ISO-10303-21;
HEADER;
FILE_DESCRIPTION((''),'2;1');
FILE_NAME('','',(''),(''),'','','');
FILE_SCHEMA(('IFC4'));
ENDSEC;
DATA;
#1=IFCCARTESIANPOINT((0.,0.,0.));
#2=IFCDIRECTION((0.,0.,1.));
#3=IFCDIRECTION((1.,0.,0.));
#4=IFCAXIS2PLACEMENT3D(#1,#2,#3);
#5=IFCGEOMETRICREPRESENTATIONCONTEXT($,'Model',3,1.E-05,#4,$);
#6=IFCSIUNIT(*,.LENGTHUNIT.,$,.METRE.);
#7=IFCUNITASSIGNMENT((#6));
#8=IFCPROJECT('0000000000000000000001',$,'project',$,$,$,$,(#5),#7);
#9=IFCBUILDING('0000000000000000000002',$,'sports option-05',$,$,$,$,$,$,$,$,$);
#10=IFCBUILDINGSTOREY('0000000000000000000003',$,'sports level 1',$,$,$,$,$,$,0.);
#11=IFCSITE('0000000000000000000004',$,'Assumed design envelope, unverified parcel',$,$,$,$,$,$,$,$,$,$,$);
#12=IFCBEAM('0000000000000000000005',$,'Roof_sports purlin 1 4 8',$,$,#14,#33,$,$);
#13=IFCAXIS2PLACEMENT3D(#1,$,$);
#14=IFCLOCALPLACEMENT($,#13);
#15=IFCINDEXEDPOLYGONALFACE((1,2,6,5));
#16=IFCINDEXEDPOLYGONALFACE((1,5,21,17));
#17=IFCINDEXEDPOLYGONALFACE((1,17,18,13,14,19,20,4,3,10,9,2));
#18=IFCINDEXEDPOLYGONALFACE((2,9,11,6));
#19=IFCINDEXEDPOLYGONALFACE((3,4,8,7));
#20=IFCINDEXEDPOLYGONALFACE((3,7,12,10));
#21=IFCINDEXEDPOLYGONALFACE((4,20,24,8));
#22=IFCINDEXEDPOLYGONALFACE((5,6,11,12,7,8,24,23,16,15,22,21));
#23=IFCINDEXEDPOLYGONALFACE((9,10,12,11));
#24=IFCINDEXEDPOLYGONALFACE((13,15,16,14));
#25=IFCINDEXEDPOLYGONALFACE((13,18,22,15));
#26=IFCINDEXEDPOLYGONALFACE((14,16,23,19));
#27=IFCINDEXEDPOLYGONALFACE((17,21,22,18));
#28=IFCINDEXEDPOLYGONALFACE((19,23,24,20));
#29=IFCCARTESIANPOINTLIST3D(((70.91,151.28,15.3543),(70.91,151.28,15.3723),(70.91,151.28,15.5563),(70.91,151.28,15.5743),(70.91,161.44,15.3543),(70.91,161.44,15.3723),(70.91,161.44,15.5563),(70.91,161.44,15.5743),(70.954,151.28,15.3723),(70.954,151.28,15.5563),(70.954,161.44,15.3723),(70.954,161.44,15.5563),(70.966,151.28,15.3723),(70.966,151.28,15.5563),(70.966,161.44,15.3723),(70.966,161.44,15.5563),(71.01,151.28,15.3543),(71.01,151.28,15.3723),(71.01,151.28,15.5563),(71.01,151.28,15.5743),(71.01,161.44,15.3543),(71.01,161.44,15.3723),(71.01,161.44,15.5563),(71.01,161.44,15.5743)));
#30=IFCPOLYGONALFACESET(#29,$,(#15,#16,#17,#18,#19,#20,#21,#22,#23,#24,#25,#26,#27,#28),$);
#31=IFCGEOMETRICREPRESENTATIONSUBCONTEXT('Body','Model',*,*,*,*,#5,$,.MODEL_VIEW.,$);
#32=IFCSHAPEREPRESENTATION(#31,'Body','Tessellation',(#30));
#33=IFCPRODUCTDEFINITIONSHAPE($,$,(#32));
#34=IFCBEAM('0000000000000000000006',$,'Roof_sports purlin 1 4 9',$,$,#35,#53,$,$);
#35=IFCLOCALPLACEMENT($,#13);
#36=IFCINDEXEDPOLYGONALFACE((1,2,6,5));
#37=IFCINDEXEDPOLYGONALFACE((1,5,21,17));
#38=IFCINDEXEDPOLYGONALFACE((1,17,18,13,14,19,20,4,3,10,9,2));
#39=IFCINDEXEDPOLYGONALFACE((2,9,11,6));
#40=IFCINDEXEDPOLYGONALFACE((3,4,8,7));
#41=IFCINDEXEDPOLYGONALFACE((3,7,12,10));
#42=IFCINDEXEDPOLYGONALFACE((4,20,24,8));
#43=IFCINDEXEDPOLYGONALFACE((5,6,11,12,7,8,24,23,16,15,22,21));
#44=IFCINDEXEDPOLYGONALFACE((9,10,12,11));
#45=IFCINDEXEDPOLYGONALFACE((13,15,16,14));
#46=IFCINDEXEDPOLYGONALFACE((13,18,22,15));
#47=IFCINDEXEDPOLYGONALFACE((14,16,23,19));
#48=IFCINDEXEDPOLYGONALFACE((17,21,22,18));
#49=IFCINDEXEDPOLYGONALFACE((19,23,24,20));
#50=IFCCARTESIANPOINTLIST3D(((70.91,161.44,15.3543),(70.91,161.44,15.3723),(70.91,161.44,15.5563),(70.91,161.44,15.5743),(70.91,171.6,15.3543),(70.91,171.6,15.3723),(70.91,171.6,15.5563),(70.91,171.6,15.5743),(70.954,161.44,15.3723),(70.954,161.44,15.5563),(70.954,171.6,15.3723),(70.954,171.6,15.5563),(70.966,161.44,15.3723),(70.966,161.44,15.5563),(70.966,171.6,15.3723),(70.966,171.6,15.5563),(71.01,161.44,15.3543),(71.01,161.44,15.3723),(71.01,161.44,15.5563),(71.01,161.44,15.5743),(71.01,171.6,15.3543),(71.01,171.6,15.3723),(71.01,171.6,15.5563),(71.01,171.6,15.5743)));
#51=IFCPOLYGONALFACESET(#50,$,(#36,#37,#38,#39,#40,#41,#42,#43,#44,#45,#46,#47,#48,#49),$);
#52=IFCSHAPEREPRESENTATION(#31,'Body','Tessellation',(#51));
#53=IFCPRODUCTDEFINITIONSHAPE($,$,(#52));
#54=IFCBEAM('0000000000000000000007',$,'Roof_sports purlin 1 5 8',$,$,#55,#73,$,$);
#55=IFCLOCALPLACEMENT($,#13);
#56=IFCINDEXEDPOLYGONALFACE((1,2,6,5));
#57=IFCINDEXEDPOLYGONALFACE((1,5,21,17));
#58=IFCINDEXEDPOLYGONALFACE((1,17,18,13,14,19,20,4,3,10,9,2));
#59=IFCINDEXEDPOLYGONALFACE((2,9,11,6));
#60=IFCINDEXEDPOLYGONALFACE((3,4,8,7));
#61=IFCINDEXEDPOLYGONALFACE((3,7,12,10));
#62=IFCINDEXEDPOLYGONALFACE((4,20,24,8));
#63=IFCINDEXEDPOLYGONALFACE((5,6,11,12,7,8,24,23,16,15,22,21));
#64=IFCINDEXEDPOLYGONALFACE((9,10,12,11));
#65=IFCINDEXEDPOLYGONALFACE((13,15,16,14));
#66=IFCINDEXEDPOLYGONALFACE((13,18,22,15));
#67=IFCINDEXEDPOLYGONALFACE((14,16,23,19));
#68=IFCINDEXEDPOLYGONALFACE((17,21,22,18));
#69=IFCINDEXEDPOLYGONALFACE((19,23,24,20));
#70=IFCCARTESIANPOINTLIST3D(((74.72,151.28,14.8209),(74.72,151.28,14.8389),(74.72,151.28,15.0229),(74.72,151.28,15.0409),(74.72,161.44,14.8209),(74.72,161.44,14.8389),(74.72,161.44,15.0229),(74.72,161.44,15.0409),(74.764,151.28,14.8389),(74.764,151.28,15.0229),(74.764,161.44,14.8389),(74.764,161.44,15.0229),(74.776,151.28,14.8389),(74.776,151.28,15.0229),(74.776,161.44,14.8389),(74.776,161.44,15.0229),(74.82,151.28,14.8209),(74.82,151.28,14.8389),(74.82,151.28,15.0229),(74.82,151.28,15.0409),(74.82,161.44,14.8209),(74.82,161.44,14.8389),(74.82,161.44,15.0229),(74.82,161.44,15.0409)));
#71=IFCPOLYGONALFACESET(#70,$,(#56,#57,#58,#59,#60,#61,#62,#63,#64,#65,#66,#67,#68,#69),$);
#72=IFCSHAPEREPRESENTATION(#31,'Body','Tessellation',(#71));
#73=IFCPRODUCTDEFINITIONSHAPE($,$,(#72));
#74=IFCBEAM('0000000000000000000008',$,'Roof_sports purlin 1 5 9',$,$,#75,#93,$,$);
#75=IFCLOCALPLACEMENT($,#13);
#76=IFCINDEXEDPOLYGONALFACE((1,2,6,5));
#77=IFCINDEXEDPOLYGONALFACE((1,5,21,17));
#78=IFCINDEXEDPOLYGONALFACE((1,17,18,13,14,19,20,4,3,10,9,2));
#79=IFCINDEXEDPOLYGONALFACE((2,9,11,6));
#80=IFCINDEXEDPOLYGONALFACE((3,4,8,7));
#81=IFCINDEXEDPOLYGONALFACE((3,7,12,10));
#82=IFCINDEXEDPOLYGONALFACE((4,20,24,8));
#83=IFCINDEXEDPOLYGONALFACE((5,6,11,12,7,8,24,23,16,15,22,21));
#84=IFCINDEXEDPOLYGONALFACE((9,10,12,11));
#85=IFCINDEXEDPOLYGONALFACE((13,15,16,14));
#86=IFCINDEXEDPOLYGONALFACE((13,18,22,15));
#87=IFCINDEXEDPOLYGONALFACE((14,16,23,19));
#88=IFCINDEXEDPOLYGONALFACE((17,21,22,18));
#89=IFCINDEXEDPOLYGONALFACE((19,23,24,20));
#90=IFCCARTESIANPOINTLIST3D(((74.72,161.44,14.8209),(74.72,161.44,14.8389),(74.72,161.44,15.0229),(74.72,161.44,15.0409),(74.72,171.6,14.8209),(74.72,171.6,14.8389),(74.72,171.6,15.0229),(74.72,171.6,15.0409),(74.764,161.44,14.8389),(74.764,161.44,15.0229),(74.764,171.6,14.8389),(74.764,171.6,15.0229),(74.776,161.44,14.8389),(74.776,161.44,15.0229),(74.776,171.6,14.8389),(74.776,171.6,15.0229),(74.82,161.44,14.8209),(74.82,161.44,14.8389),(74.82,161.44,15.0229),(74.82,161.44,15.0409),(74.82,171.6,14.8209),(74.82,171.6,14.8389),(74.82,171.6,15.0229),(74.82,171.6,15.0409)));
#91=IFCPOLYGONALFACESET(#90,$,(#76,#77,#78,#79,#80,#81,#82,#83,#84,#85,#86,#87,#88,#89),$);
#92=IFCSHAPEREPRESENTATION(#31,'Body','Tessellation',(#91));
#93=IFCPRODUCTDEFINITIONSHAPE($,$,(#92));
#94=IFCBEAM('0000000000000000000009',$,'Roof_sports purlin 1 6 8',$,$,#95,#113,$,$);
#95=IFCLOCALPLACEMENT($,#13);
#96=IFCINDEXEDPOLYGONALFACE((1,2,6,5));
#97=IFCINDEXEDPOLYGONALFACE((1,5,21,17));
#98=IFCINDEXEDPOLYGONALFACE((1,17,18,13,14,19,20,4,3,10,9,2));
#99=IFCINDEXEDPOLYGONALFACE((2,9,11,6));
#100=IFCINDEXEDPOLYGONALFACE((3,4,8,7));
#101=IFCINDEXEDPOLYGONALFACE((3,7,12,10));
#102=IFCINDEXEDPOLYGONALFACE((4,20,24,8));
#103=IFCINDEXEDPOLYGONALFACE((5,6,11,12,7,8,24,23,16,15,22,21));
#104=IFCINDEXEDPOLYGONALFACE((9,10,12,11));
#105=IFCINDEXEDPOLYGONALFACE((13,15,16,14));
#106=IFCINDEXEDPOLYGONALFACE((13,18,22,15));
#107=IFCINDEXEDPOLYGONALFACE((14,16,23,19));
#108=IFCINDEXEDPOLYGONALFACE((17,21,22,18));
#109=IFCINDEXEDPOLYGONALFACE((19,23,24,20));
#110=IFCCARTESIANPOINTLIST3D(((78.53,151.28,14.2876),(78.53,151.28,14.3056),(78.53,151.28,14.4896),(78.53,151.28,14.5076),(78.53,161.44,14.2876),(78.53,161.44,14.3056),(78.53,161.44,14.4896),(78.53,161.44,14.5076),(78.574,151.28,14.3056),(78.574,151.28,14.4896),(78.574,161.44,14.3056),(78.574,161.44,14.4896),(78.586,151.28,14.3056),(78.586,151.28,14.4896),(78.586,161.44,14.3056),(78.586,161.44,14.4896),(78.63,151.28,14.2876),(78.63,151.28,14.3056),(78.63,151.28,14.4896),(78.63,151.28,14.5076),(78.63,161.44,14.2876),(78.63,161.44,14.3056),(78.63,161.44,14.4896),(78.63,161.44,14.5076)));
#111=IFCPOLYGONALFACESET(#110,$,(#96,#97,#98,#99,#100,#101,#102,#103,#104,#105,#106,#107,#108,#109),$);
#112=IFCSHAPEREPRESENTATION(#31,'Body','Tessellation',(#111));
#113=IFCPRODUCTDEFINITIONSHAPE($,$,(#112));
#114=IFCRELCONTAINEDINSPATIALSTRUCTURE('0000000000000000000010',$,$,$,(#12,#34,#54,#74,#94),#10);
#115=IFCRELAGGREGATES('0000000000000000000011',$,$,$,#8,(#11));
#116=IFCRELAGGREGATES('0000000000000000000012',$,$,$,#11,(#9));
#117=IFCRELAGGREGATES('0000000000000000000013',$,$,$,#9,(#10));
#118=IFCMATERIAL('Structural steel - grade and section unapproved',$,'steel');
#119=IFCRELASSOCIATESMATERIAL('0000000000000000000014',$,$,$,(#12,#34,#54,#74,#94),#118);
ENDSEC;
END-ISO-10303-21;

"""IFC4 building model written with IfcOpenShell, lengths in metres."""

from ifc_helpers import new_model, si_unit, frame, origin_with_axes, place, context, subcontext, project, spatial, i_section, extrude, material, element, save


model = new_model("IFC4")

# Units and contexts
model_context = context("Model", 3, precision=1e-05, world=origin_with_axes())
body_context = subcontext(model_context, "Body", "Model", "MODEL_VIEW")
ifc_project = project(units=[si_unit("LENGTHUNIT", "METRE")], contexts=[model_context])

# Site, building, storey
site = spatial("IfcSite", under=ifc_project, Name="Assumed design envelope, unverified parcel")
building = spatial("IfcBuilding", under=site, Name="sports option-05")
storey = spatial("IfcBuildingStorey", under=building, Name="sports level 1", Elevation=0.0)

# Beams
ifc_material = material(Name="Structural steel - grade and section unapproved", Category="steel")
for number, where, z_axis, x_axis, name in (
    (1, (70.96, 151.28, 15.4643), (0.0, 1.0, 0.0), (-1.0, 0.0, 0.0), "Roof_sports purlin 1 4 8"),
    (2, (70.96, 161.44, 15.4643), (0.0, 1.0, 0.0), (-1.0, 0.0, 0.0), "Roof_sports purlin 1 4 9"),
    (3, (74.77, 151.28, 14.9309), (0.0, 1.0, 0.0), (-1.0, 0.0, 0.0), "Roof_sports purlin 1 5 8"),
    (4, (74.77, 161.44, 14.9309), (0.0, 1.0, 0.0), (-1.0, 0.0, 0.0), "Roof_sports purlin 1 5 9"),
    (5, (78.58, 151.28, 14.3976), (0.0, 1.0, 0.0), (-1.0, 0.0, 0.0), "Roof_sports purlin 1 6 8"),
):
    element("IfcBeam", number, at=place(None, frame(where, z_axis=z_axis, x_axis=x_axis)), inside=storey, material=ifc_material, Name=name, context=body_context, shape_type="SweptSolid", body=[
        extrude(i_section(OverallWidth=0.1, OverallDepth=0.22, WebThickness=0.012, FlangeThickness=0.018, FilletRadius=0.0), origin_with_axes(), (0.0, 0.0, 1.0), 10.16),
    ])

save(model, "model.ifc")
